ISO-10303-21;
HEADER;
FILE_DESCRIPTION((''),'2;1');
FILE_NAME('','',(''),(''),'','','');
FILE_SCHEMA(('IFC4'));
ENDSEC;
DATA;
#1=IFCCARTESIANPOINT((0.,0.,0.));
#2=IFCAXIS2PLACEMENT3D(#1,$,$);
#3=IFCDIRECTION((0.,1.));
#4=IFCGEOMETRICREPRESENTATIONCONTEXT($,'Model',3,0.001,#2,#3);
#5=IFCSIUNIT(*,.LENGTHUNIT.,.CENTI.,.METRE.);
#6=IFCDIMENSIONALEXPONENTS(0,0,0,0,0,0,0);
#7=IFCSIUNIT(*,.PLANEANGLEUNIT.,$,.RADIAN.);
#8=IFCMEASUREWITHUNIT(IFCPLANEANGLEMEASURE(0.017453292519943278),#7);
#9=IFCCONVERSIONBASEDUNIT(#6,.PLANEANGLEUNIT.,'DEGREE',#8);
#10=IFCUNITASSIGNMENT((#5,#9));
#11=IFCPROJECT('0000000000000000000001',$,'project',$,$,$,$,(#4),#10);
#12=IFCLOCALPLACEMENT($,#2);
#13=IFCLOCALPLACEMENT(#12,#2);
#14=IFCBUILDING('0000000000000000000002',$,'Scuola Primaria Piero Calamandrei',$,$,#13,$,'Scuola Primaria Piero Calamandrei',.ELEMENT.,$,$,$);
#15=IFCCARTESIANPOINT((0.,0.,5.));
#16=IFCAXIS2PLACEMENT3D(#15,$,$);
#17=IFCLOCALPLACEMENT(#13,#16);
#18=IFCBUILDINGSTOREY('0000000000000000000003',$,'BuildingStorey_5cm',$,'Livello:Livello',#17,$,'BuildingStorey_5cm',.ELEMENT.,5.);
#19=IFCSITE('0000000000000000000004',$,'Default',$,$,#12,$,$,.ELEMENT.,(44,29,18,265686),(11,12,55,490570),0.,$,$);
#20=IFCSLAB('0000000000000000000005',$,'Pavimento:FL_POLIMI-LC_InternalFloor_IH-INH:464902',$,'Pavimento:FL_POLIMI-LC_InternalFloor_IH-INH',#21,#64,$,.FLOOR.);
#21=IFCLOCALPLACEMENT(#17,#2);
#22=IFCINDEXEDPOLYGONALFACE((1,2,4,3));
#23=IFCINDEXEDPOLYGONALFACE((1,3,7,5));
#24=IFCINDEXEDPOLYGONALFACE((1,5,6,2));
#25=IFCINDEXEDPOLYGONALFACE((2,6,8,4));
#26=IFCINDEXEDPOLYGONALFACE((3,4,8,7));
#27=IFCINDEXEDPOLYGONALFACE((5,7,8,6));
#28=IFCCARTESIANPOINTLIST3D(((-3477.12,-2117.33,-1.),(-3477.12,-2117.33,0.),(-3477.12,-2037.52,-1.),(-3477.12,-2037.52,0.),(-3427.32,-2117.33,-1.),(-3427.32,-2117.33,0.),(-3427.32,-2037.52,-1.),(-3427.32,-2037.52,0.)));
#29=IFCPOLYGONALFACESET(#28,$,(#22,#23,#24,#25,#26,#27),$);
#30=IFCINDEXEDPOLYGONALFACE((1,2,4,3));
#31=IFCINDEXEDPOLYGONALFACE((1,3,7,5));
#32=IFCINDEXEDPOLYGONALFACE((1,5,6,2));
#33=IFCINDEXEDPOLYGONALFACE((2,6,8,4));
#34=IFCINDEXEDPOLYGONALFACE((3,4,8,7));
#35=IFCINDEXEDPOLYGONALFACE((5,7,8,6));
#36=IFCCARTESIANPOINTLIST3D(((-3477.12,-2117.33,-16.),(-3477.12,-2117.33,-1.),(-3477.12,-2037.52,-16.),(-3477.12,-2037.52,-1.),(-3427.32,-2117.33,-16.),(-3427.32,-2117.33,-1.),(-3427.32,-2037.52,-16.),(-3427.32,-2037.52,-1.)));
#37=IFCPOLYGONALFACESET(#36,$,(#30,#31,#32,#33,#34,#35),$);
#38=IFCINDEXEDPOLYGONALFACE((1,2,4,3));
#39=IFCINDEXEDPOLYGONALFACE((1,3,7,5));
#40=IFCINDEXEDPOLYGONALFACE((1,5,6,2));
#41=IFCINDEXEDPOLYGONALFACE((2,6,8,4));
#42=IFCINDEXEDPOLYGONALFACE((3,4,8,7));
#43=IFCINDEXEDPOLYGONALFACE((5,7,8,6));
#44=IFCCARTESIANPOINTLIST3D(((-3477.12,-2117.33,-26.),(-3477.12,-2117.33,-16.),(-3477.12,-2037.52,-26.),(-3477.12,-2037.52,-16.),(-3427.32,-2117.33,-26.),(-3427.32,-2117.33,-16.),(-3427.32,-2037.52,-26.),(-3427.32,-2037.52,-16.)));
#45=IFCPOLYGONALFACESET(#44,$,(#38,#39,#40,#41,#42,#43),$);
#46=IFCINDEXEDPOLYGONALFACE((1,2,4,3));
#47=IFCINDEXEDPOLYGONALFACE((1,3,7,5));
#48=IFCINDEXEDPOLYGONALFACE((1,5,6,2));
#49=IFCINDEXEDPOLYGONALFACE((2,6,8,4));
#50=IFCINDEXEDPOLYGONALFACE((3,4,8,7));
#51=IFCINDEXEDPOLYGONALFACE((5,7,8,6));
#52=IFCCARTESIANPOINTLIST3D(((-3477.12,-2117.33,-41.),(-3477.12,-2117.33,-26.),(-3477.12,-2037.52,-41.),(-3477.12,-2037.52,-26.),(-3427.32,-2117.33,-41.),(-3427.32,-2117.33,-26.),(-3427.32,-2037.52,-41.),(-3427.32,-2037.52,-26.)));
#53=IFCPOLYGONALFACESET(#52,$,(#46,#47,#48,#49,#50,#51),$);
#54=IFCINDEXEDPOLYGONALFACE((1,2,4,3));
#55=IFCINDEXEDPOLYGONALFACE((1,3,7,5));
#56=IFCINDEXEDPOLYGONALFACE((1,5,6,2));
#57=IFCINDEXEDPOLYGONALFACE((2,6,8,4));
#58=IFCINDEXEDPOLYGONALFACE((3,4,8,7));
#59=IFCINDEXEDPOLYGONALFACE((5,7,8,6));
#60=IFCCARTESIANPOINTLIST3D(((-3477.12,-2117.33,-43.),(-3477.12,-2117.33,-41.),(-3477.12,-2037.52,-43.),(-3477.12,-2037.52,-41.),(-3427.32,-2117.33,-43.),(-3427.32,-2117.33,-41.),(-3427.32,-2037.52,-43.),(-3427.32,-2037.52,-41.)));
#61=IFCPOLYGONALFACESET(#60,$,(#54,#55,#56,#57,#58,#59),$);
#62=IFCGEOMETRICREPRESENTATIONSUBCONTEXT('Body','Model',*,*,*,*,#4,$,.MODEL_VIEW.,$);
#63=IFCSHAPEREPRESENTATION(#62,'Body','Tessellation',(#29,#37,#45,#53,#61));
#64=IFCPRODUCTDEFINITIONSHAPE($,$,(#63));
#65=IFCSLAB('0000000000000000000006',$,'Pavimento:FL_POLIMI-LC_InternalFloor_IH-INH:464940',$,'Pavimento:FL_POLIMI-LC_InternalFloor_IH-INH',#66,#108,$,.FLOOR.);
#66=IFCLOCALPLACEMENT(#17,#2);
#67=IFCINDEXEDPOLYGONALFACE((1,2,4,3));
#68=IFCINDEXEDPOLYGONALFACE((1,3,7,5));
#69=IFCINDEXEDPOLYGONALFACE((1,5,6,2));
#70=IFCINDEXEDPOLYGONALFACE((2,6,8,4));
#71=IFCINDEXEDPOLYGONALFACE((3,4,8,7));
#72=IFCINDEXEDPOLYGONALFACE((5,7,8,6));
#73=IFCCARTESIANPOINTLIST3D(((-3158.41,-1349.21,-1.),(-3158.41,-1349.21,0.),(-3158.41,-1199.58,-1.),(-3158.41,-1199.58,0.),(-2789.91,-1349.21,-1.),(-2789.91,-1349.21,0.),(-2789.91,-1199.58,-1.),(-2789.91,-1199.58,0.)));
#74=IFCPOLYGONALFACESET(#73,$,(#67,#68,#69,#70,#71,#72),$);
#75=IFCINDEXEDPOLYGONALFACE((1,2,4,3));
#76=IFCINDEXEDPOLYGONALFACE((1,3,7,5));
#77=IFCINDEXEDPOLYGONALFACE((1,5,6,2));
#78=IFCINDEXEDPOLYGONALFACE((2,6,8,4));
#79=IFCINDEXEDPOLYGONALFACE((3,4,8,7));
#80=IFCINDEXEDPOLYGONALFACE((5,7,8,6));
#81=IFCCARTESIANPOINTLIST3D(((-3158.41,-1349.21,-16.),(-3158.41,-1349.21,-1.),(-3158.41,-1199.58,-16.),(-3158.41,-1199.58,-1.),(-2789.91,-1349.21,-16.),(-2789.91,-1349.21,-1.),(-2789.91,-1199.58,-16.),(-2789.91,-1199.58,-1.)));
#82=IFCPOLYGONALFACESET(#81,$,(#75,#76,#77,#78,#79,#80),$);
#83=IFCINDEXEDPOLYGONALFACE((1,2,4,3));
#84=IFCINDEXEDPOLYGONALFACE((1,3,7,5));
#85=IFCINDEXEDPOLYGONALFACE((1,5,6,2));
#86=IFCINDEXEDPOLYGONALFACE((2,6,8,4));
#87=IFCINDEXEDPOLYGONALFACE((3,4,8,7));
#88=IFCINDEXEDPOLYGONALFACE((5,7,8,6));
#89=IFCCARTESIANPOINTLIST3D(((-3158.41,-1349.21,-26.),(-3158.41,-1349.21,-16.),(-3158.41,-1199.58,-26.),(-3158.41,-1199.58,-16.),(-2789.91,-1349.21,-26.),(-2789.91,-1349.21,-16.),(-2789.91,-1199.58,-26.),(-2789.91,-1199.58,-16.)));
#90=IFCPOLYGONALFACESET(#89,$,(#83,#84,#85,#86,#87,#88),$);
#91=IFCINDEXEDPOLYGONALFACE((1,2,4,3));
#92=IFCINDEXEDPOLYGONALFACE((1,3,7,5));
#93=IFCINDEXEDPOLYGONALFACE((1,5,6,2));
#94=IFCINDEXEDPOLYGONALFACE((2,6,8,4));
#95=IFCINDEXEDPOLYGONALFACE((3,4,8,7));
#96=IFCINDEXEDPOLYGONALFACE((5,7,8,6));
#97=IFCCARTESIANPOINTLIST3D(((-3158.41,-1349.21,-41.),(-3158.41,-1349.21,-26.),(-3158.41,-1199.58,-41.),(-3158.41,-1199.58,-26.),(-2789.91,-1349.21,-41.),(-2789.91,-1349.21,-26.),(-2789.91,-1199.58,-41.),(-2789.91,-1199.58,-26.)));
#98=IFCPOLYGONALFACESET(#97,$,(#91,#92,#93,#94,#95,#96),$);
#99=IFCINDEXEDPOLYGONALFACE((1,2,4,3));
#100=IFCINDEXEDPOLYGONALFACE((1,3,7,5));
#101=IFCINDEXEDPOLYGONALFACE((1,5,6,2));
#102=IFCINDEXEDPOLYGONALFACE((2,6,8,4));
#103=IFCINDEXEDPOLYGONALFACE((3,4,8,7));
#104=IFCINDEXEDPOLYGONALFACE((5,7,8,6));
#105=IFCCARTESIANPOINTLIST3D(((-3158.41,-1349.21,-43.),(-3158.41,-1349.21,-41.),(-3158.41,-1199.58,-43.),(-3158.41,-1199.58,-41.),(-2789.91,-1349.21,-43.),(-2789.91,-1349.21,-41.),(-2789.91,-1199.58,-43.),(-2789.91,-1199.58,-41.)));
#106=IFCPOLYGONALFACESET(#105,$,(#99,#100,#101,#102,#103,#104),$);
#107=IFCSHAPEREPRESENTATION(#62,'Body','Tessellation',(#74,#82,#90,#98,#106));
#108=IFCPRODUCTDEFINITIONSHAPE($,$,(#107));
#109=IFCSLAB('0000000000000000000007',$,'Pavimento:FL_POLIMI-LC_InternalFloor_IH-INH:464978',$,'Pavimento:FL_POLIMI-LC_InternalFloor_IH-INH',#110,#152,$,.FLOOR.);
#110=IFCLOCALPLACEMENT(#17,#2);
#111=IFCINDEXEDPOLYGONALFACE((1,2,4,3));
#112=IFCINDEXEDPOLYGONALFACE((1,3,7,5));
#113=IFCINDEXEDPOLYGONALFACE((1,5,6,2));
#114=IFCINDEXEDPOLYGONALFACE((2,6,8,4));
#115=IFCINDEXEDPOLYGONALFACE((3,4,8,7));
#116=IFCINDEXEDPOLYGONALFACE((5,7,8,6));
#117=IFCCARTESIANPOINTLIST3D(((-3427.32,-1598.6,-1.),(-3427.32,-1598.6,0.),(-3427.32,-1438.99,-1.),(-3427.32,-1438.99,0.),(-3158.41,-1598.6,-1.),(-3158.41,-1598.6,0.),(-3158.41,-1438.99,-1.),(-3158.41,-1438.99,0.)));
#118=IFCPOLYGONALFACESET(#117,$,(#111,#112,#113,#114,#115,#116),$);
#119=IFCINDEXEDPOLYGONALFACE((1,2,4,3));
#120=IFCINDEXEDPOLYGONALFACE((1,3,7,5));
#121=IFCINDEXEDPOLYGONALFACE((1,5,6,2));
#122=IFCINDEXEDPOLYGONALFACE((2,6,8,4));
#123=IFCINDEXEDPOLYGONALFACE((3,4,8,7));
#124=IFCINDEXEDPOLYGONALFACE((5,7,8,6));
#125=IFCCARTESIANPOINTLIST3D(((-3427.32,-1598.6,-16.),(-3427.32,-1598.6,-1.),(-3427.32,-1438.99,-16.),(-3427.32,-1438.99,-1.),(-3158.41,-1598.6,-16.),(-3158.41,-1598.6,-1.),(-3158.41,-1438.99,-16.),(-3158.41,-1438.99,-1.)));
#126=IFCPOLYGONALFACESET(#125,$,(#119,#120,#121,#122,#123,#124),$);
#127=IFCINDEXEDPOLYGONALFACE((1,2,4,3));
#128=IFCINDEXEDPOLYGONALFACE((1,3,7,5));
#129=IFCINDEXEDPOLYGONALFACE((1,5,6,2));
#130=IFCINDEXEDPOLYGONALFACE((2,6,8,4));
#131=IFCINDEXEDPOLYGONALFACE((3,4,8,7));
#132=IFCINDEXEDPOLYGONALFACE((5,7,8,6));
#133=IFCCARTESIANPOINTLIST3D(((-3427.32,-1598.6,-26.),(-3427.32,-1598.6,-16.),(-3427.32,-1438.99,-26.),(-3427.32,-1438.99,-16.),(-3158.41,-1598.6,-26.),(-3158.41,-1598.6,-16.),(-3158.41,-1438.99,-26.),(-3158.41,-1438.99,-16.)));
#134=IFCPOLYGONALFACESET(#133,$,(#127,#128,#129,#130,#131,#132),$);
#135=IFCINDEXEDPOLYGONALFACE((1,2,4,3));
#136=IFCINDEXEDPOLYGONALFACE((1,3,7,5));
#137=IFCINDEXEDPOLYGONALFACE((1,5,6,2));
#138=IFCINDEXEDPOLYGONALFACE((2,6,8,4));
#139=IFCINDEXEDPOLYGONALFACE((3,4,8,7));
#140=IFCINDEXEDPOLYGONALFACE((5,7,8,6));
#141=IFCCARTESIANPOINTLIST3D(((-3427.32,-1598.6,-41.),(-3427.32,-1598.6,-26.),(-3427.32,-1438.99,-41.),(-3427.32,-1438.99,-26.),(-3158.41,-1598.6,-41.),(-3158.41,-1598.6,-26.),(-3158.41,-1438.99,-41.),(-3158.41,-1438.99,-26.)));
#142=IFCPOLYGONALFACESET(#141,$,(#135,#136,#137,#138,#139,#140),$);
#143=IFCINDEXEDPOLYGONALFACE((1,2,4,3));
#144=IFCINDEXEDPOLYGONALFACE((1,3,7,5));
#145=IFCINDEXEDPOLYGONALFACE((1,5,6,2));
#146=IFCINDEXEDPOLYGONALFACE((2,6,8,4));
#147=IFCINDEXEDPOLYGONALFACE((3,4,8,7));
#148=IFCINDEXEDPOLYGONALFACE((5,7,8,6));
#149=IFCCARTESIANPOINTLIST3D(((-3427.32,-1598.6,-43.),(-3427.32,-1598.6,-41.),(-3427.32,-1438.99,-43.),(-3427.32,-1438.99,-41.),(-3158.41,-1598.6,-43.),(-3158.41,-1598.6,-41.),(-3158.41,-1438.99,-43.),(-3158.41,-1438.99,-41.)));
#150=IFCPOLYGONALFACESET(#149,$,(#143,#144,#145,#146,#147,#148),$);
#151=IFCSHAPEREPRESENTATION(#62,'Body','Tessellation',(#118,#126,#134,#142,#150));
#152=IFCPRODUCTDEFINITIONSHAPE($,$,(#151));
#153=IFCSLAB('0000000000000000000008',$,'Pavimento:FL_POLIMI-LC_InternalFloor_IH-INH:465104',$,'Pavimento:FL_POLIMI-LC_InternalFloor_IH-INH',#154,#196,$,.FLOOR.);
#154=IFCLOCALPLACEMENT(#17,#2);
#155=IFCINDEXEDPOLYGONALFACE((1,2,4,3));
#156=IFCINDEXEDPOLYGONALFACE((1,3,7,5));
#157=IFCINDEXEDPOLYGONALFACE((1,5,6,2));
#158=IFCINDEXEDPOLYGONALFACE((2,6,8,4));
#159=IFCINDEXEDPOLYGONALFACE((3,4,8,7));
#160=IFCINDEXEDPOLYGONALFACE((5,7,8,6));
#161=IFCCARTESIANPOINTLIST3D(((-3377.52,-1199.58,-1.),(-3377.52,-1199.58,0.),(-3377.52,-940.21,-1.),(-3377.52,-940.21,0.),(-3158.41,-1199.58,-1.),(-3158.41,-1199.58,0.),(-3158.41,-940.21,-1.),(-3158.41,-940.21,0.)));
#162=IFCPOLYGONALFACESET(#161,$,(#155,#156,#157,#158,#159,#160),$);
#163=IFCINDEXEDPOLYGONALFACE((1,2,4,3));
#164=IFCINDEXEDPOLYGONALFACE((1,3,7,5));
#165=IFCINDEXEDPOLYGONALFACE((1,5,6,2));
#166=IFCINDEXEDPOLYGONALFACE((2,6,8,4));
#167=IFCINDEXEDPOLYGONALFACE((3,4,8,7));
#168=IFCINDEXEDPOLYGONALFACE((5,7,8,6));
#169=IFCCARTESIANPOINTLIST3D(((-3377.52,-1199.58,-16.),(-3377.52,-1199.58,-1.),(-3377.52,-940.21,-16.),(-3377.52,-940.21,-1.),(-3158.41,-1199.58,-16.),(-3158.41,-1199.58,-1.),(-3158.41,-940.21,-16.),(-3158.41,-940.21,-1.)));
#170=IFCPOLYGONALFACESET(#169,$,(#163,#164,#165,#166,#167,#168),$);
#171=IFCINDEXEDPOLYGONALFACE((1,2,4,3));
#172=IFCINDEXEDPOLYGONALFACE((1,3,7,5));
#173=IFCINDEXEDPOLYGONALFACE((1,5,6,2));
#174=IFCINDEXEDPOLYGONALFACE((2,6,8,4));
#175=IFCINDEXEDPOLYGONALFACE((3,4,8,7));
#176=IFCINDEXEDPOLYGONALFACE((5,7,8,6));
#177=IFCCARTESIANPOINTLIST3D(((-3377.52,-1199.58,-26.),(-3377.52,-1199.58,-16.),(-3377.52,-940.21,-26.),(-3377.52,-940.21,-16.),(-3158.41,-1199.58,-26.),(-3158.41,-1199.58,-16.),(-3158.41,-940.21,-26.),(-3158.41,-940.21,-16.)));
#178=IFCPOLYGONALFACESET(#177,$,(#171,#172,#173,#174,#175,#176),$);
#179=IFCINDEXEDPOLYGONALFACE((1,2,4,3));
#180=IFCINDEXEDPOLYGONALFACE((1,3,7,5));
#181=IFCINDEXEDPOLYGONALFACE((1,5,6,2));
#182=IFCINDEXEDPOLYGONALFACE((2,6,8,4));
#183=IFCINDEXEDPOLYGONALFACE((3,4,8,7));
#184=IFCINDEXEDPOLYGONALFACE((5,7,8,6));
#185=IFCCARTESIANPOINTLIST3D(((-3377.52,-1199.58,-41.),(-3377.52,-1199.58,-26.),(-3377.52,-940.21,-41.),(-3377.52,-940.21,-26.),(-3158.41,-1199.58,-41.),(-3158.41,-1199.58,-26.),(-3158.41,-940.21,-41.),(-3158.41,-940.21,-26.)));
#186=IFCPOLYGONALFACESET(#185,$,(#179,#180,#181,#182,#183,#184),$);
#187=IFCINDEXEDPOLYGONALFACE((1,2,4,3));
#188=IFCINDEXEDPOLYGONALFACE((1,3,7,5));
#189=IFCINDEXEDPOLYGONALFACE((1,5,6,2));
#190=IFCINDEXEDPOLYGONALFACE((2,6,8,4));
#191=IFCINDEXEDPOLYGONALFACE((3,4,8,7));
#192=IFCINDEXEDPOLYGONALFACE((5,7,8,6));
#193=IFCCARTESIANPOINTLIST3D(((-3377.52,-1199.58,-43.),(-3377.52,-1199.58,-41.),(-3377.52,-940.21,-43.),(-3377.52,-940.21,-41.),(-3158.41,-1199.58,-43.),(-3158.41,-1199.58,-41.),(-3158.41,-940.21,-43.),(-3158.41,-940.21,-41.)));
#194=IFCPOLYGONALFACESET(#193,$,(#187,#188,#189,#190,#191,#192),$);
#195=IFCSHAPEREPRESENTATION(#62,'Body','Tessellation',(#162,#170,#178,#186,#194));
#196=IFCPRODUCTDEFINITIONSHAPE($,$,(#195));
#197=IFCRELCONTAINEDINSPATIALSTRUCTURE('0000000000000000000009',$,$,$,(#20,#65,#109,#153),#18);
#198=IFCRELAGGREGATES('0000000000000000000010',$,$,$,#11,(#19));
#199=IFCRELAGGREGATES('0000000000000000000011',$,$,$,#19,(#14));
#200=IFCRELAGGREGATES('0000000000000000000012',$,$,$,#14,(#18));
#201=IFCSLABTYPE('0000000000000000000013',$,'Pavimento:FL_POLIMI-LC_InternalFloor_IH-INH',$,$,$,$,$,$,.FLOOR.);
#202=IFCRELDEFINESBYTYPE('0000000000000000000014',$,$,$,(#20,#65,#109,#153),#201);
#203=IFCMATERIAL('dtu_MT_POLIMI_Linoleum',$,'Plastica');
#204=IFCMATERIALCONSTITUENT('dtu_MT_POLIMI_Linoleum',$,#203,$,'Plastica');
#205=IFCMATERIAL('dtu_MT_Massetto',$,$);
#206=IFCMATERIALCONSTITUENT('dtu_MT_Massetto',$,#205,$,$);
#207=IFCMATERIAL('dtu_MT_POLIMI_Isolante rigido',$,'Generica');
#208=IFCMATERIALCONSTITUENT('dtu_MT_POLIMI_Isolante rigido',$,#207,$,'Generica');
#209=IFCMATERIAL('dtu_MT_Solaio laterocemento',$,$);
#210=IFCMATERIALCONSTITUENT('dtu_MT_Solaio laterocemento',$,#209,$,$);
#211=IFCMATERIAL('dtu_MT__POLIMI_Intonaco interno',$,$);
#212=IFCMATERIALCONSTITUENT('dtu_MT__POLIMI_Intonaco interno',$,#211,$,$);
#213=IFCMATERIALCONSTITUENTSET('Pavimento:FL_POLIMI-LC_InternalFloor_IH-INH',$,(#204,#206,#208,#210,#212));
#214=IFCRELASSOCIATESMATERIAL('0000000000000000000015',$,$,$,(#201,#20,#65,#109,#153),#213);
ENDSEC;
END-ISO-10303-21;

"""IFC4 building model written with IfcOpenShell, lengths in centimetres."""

from ifc_helpers import new_model, entity, si_unit, converted_unit, direction, frame, origin, place, context, subcontext, project, spatial, indexed_curve, outline, extrude, material, constituent, constituent_set, type_object, element, save


model = new_model("IFC4")

# Units and contexts
model_context = context("Model", 3, precision=0.001, world=origin(), true_north=direction((0.0, 1.0)))
body_context = subcontext(model_context, "Body", "Model", "MODEL_VIEW")
ifc_project = project(units=[si_unit("LENGTHUNIT", "METRE", prefix="CENTI"), converted_unit("PLANEANGLEUNIT", "DEGREE", entity("IfcPlaneAngleMeasure", 0.017453292519943278), si_unit("PLANEANGLEUNIT", "RADIAN"), dimensions=[0, 0, 0, 0, 0, 0, 0])], contexts=[model_context])

# Site, building, storey
site_placement = place(None, origin())
site = spatial("IfcSite", under=ifc_project, at=site_placement, Name="Default", CompositionType="ELEMENT", RefLatitude=(44, 29, 18, 265686), RefLongitude=(11, 12, 55, 490570), RefElevation=0.0)
building_placement = place(site_placement, origin())
building = spatial("IfcBuilding", under=site, at=building_placement, Name="Scuola Primaria Piero Calamandrei", LongName="Scuola Primaria Piero Calamandrei", CompositionType="ELEMENT")
storey_placement = place(building_placement, frame((0.0, 0.0, 5.0)))
storey = spatial("IfcBuildingStorey", under=building, at=storey_placement, Name="BuildingStorey_5cm", ObjectType="Livello:Livello", LongName="BuildingStorey_5cm", CompositionType="ELEMENT", Elevation=5.0)

# Slabs
ifc_material_1 = material(Name="dtu_MT_POLIMI_Linoleum", Category="Plastica")
ifc_constituent_1 = constituent(ifc_material_1, Name="dtu_MT_POLIMI_Linoleum", Category="Plastica")
ifc_material_2 = material(Name="dtu_MT_Massetto")
ifc_constituent_2 = constituent(ifc_material_2, Name="dtu_MT_Massetto")
ifc_material_3 = material(Name="dtu_MT_POLIMI_Isolante rigido", Category="Generica")
ifc_constituent_3 = constituent(ifc_material_3, Name="dtu_MT_POLIMI_Isolante rigido", Category="Generica")
ifc_material_4 = material(Name="dtu_MT_Solaio laterocemento")
ifc_constituent_4 = constituent(ifc_material_4, Name="dtu_MT_Solaio laterocemento")
ifc_material_5 = material(Name="dtu_MT__POLIMI_Intonaco interno")
ifc_constituent_5 = constituent(ifc_material_5, Name="dtu_MT__POLIMI_Intonaco interno")
ifc_constituent_set_1 = constituent_set(constituents=[ifc_constituent_1, ifc_constituent_2, ifc_constituent_3, ifc_constituent_4, ifc_constituent_5], Name="Pavimento:FL_POLIMI-LC_InternalFloor_IH-INH")
slab_type_1 = type_object("IfcSlabType", Name="Pavimento:FL_POLIMI-LC_InternalFloor_IH-INH", PredefinedType="FLOOR", material=ifc_constituent_set_1)
slab_1_placement = place(storey_placement, origin())
element("IfcSlab", 1, at=slab_1_placement, inside=storey, type_object=slab_type_1, material=ifc_constituent_set_1, Name="Pavimento:FL_POLIMI-LC_InternalFloor_IH-INH:464902", ObjectType="Pavimento:FL_POLIMI-LC_InternalFloor_IH-INH", PredefinedType="FLOOR", context=body_context, shape_type="SweptSolid", body=[
    extrude(outline(indexed_curve([(-39.9, -24.9), (39.9, -24.9), (39.9, 24.9), (-39.9, 24.9), (-39.9, -24.9)], self_intersect=False)), frame((-3452.22, -2077.42, -1.0), z_axis=(0.0, 0.0, 1.0), x_axis=(0.0, 1.0, 0.0)), (0.0, 0.0, 1.0), 1.0),
    extrude(outline(indexed_curve([(-39.9, -24.9), (39.9, -24.9), (39.9, 24.9), (-39.9, 24.9), (-39.9, -24.9)], self_intersect=False)), frame((-3452.22, -2077.42, -16.0), z_axis=(0.0, 0.0, 1.0), x_axis=(0.0, 1.0, 0.0)), (0.0, 0.0, 1.0), 15.0),
    extrude(outline(indexed_curve([(-39.9, -24.9), (39.9, -24.9), (39.9, 24.9), (-39.9, 24.9), (-39.9, -24.9)], self_intersect=False)), frame((-3452.22, -2077.42, -26.0), z_axis=(0.0, 0.0, 1.0), x_axis=(0.0, 1.0, 0.0)), (0.0, 0.0, 1.0), 10.0),
    extrude(outline(indexed_curve([(-39.9, -24.9), (39.9, -24.9), (39.9, 24.9), (-39.9, 24.9), (-39.9, -24.9)], self_intersect=False)), frame((-3452.22, -2077.42, -41.0), z_axis=(0.0, 0.0, 1.0), x_axis=(0.0, 1.0, 0.0)), (0.0, 0.0, 1.0), 15.0),
    extrude(outline(indexed_curve([(-39.9, -24.9), (39.9, -24.9), (39.9, 24.9), (-39.9, 24.9), (-39.9, -24.9)], self_intersect=False)), frame((-3452.22, -2077.42, -43.0), z_axis=(0.0, 0.0, 1.0), x_axis=(0.0, 1.0, 0.0)), (0.0, 0.0, 1.0), 2.0),
])
slab_2_placement = place(storey_placement, origin())
element("IfcSlab", 2, at=slab_2_placement, inside=storey, type_object=slab_type_1, material=ifc_constituent_set_1, Name="Pavimento:FL_POLIMI-LC_InternalFloor_IH-INH:464940", ObjectType="Pavimento:FL_POLIMI-LC_InternalFloor_IH-INH", PredefinedType="FLOOR", context=body_context, shape_type="SweptSolid", body=[
    extrude(outline(indexed_curve([(-184.25, -74.82), (184.25, -74.82), (184.25, 74.82), (-184.25, 74.82), (-184.25, -74.82)], self_intersect=False)), frame((-2974.16, -1274.39, -1.0), z_axis=(0.0, 0.0, 1.0), x_axis=(-1.0, 0.0, 0.0)), (0.0, 0.0, 1.0), 1.0),
    extrude(outline(indexed_curve([(-184.25, -74.82), (184.25, -74.82), (184.25, 74.82), (-184.25, 74.82), (-184.25, -74.82)], self_intersect=False)), frame((-2974.16, -1274.39, -16.0), z_axis=(0.0, 0.0, 1.0), x_axis=(-1.0, 0.0, 0.0)), (0.0, 0.0, 1.0), 15.0),
    extrude(outline(indexed_curve([(-184.25, -74.82), (184.25, -74.82), (184.25, 74.82), (-184.25, 74.82), (-184.25, -74.82)], self_intersect=False)), frame((-2974.16, -1274.39, -26.0), z_axis=(0.0, 0.0, 1.0), x_axis=(-1.0, 0.0, 0.0)), (0.0, 0.0, 1.0), 10.0),
    extrude(outline(indexed_curve([(-184.25, -74.82), (184.25, -74.82), (184.25, 74.82), (-184.25, 74.82), (-184.25, -74.82)], self_intersect=False)), frame((-2974.16, -1274.39, -41.0), z_axis=(0.0, 0.0, 1.0), x_axis=(-1.0, 0.0, 0.0)), (0.0, 0.0, 1.0), 15.0),
    extrude(outline(indexed_curve([(-184.25, -74.82), (184.25, -74.82), (184.25, 74.82), (-184.25, 74.82), (-184.25, -74.82)], self_intersect=False)), frame((-2974.16, -1274.39, -43.0), z_axis=(0.0, 0.0, 1.0), x_axis=(-1.0, 0.0, 0.0)), (0.0, 0.0, 1.0), 2.0),
])
slab_3_placement = place(storey_placement, origin())
element("IfcSlab", 3, at=slab_3_placement, inside=storey, type_object=slab_type_1, material=ifc_constituent_set_1, Name="Pavimento:FL_POLIMI-LC_InternalFloor_IH-INH:464978", ObjectType="Pavimento:FL_POLIMI-LC_InternalFloor_IH-INH", PredefinedType="FLOOR", context=body_context, shape_type="SweptSolid", body=[
    extrude(outline(indexed_curve([(-79.8, -134.45), (79.8, -134.45), (79.8, 134.45), (-79.8, 134.45), (-79.8, -134.45)], self_intersect=False)), frame((-3292.87, -1518.79, -1.0), z_axis=(0.0, 0.0, 1.0), x_axis=(0.0, 1.0, 0.0)), (0.0, 0.0, 1.0), 1.0),
    extrude(outline(indexed_curve([(-79.8, -134.45), (79.8, -134.45), (79.8, 134.45), (-79.8, 134.45), (-79.8, -134.45)], self_intersect=False)), frame((-3292.87, -1518.79, -16.0), z_axis=(0.0, 0.0, 1.0), x_axis=(0.0, 1.0, 0.0)), (0.0, 0.0, 1.0), 15.0),
    extrude(outline(indexed_curve([(-79.8, -134.45), (79.8, -134.45), (79.8, 134.45), (-79.8, 134.45), (-79.8, -134.45)], self_intersect=False)), frame((-3292.87, -1518.79, -26.0), z_axis=(0.0, 0.0, 1.0), x_axis=(0.0, 1.0, 0.0)), (0.0, 0.0, 1.0), 10.0),
    extrude(outline(indexed_curve([(-79.8, -134.45), (79.8, -134.45), (79.8, 134.45), (-79.8, 134.45), (-79.8, -134.45)], self_intersect=False)), frame((-3292.87, -1518.79, -41.0), z_axis=(0.0, 0.0, 1.0), x_axis=(0.0, 1.0, 0.0)), (0.0, 0.0, 1.0), 15.0),
    extrude(outline(indexed_curve([(-79.8, -134.45), (79.8, -134.45), (79.8, 134.45), (-79.8, 134.45), (-79.8, -134.45)], self_intersect=False)), frame((-3292.87, -1518.79, -43.0), z_axis=(0.0, 0.0, 1.0), x_axis=(0.0, 1.0, 0.0)), (0.0, 0.0, 1.0), 2.0),
])
slab_4_placement = place(storey_placement, origin())
element("IfcSlab", 4, at=slab_4_placement, inside=storey, type_object=slab_type_1, material=ifc_constituent_set_1, Name="Pavimento:FL_POLIMI-LC_InternalFloor_IH-INH:465104", ObjectType="Pavimento:FL_POLIMI-LC_InternalFloor_IH-INH", PredefinedType="FLOOR", context=body_context, shape_type="SweptSolid", body=[
    extrude(outline(indexed_curve([(-109.56, -129.68), (109.56, -129.68), (109.56, 129.68), (-109.56, 129.68), (-109.56, -129.68)], self_intersect=False)), frame((-3267.97, -1069.89, -1.0), z_axis=(0.0, 0.0, 1.0), x_axis=(-1.0, 0.0, 0.0)), (0.0, 0.0, 1.0), 1.0),
    extrude(outline(indexed_curve([(-109.56, -129.68), (109.56, -129.68), (109.56, 129.68), (-109.56, 129.68), (-109.56, -129.68)], self_intersect=False)), frame((-3267.97, -1069.89, -16.0), z_axis=(0.0, 0.0, 1.0), x_axis=(-1.0, 0.0, 0.0)), (0.0, 0.0, 1.0), 15.0),
    extrude(outline(indexed_curve([(-109.56, -129.68), (109.56, -129.68), (109.56, 129.68), (-109.56, 129.68), (-109.56, -129.68)], self_intersect=False)), frame((-3267.97, -1069.89, -26.0), z_axis=(0.0, 0.0, 1.0), x_axis=(-1.0, 0.0, 0.0)), (0.0, 0.0, 1.0), 10.0),
    extrude(outline(indexed_curve([(-109.56, -129.68), (109.56, -129.68), (109.56, 129.68), (-109.56, 129.68), (-109.56, -129.68)], self_intersect=False)), frame((-3267.97, -1069.89, -41.0), z_axis=(0.0, 0.0, 1.0), x_axis=(-1.0, 0.0, 0.0)), (0.0, 0.0, 1.0), 15.0),
    extrude(outline(indexed_curve([(-109.56, -129.68), (109.56, -129.68), (109.56, 129.68), (-109.56, 129.68), (-109.56, -129.68)], self_intersect=False)), frame((-3267.97, -1069.89, -43.0), z_axis=(0.0, 0.0, 1.0), x_axis=(-1.0, 0.0, 0.0)), (0.0, 0.0, 1.0), 2.0),
])

save(model, "model.ifc")
